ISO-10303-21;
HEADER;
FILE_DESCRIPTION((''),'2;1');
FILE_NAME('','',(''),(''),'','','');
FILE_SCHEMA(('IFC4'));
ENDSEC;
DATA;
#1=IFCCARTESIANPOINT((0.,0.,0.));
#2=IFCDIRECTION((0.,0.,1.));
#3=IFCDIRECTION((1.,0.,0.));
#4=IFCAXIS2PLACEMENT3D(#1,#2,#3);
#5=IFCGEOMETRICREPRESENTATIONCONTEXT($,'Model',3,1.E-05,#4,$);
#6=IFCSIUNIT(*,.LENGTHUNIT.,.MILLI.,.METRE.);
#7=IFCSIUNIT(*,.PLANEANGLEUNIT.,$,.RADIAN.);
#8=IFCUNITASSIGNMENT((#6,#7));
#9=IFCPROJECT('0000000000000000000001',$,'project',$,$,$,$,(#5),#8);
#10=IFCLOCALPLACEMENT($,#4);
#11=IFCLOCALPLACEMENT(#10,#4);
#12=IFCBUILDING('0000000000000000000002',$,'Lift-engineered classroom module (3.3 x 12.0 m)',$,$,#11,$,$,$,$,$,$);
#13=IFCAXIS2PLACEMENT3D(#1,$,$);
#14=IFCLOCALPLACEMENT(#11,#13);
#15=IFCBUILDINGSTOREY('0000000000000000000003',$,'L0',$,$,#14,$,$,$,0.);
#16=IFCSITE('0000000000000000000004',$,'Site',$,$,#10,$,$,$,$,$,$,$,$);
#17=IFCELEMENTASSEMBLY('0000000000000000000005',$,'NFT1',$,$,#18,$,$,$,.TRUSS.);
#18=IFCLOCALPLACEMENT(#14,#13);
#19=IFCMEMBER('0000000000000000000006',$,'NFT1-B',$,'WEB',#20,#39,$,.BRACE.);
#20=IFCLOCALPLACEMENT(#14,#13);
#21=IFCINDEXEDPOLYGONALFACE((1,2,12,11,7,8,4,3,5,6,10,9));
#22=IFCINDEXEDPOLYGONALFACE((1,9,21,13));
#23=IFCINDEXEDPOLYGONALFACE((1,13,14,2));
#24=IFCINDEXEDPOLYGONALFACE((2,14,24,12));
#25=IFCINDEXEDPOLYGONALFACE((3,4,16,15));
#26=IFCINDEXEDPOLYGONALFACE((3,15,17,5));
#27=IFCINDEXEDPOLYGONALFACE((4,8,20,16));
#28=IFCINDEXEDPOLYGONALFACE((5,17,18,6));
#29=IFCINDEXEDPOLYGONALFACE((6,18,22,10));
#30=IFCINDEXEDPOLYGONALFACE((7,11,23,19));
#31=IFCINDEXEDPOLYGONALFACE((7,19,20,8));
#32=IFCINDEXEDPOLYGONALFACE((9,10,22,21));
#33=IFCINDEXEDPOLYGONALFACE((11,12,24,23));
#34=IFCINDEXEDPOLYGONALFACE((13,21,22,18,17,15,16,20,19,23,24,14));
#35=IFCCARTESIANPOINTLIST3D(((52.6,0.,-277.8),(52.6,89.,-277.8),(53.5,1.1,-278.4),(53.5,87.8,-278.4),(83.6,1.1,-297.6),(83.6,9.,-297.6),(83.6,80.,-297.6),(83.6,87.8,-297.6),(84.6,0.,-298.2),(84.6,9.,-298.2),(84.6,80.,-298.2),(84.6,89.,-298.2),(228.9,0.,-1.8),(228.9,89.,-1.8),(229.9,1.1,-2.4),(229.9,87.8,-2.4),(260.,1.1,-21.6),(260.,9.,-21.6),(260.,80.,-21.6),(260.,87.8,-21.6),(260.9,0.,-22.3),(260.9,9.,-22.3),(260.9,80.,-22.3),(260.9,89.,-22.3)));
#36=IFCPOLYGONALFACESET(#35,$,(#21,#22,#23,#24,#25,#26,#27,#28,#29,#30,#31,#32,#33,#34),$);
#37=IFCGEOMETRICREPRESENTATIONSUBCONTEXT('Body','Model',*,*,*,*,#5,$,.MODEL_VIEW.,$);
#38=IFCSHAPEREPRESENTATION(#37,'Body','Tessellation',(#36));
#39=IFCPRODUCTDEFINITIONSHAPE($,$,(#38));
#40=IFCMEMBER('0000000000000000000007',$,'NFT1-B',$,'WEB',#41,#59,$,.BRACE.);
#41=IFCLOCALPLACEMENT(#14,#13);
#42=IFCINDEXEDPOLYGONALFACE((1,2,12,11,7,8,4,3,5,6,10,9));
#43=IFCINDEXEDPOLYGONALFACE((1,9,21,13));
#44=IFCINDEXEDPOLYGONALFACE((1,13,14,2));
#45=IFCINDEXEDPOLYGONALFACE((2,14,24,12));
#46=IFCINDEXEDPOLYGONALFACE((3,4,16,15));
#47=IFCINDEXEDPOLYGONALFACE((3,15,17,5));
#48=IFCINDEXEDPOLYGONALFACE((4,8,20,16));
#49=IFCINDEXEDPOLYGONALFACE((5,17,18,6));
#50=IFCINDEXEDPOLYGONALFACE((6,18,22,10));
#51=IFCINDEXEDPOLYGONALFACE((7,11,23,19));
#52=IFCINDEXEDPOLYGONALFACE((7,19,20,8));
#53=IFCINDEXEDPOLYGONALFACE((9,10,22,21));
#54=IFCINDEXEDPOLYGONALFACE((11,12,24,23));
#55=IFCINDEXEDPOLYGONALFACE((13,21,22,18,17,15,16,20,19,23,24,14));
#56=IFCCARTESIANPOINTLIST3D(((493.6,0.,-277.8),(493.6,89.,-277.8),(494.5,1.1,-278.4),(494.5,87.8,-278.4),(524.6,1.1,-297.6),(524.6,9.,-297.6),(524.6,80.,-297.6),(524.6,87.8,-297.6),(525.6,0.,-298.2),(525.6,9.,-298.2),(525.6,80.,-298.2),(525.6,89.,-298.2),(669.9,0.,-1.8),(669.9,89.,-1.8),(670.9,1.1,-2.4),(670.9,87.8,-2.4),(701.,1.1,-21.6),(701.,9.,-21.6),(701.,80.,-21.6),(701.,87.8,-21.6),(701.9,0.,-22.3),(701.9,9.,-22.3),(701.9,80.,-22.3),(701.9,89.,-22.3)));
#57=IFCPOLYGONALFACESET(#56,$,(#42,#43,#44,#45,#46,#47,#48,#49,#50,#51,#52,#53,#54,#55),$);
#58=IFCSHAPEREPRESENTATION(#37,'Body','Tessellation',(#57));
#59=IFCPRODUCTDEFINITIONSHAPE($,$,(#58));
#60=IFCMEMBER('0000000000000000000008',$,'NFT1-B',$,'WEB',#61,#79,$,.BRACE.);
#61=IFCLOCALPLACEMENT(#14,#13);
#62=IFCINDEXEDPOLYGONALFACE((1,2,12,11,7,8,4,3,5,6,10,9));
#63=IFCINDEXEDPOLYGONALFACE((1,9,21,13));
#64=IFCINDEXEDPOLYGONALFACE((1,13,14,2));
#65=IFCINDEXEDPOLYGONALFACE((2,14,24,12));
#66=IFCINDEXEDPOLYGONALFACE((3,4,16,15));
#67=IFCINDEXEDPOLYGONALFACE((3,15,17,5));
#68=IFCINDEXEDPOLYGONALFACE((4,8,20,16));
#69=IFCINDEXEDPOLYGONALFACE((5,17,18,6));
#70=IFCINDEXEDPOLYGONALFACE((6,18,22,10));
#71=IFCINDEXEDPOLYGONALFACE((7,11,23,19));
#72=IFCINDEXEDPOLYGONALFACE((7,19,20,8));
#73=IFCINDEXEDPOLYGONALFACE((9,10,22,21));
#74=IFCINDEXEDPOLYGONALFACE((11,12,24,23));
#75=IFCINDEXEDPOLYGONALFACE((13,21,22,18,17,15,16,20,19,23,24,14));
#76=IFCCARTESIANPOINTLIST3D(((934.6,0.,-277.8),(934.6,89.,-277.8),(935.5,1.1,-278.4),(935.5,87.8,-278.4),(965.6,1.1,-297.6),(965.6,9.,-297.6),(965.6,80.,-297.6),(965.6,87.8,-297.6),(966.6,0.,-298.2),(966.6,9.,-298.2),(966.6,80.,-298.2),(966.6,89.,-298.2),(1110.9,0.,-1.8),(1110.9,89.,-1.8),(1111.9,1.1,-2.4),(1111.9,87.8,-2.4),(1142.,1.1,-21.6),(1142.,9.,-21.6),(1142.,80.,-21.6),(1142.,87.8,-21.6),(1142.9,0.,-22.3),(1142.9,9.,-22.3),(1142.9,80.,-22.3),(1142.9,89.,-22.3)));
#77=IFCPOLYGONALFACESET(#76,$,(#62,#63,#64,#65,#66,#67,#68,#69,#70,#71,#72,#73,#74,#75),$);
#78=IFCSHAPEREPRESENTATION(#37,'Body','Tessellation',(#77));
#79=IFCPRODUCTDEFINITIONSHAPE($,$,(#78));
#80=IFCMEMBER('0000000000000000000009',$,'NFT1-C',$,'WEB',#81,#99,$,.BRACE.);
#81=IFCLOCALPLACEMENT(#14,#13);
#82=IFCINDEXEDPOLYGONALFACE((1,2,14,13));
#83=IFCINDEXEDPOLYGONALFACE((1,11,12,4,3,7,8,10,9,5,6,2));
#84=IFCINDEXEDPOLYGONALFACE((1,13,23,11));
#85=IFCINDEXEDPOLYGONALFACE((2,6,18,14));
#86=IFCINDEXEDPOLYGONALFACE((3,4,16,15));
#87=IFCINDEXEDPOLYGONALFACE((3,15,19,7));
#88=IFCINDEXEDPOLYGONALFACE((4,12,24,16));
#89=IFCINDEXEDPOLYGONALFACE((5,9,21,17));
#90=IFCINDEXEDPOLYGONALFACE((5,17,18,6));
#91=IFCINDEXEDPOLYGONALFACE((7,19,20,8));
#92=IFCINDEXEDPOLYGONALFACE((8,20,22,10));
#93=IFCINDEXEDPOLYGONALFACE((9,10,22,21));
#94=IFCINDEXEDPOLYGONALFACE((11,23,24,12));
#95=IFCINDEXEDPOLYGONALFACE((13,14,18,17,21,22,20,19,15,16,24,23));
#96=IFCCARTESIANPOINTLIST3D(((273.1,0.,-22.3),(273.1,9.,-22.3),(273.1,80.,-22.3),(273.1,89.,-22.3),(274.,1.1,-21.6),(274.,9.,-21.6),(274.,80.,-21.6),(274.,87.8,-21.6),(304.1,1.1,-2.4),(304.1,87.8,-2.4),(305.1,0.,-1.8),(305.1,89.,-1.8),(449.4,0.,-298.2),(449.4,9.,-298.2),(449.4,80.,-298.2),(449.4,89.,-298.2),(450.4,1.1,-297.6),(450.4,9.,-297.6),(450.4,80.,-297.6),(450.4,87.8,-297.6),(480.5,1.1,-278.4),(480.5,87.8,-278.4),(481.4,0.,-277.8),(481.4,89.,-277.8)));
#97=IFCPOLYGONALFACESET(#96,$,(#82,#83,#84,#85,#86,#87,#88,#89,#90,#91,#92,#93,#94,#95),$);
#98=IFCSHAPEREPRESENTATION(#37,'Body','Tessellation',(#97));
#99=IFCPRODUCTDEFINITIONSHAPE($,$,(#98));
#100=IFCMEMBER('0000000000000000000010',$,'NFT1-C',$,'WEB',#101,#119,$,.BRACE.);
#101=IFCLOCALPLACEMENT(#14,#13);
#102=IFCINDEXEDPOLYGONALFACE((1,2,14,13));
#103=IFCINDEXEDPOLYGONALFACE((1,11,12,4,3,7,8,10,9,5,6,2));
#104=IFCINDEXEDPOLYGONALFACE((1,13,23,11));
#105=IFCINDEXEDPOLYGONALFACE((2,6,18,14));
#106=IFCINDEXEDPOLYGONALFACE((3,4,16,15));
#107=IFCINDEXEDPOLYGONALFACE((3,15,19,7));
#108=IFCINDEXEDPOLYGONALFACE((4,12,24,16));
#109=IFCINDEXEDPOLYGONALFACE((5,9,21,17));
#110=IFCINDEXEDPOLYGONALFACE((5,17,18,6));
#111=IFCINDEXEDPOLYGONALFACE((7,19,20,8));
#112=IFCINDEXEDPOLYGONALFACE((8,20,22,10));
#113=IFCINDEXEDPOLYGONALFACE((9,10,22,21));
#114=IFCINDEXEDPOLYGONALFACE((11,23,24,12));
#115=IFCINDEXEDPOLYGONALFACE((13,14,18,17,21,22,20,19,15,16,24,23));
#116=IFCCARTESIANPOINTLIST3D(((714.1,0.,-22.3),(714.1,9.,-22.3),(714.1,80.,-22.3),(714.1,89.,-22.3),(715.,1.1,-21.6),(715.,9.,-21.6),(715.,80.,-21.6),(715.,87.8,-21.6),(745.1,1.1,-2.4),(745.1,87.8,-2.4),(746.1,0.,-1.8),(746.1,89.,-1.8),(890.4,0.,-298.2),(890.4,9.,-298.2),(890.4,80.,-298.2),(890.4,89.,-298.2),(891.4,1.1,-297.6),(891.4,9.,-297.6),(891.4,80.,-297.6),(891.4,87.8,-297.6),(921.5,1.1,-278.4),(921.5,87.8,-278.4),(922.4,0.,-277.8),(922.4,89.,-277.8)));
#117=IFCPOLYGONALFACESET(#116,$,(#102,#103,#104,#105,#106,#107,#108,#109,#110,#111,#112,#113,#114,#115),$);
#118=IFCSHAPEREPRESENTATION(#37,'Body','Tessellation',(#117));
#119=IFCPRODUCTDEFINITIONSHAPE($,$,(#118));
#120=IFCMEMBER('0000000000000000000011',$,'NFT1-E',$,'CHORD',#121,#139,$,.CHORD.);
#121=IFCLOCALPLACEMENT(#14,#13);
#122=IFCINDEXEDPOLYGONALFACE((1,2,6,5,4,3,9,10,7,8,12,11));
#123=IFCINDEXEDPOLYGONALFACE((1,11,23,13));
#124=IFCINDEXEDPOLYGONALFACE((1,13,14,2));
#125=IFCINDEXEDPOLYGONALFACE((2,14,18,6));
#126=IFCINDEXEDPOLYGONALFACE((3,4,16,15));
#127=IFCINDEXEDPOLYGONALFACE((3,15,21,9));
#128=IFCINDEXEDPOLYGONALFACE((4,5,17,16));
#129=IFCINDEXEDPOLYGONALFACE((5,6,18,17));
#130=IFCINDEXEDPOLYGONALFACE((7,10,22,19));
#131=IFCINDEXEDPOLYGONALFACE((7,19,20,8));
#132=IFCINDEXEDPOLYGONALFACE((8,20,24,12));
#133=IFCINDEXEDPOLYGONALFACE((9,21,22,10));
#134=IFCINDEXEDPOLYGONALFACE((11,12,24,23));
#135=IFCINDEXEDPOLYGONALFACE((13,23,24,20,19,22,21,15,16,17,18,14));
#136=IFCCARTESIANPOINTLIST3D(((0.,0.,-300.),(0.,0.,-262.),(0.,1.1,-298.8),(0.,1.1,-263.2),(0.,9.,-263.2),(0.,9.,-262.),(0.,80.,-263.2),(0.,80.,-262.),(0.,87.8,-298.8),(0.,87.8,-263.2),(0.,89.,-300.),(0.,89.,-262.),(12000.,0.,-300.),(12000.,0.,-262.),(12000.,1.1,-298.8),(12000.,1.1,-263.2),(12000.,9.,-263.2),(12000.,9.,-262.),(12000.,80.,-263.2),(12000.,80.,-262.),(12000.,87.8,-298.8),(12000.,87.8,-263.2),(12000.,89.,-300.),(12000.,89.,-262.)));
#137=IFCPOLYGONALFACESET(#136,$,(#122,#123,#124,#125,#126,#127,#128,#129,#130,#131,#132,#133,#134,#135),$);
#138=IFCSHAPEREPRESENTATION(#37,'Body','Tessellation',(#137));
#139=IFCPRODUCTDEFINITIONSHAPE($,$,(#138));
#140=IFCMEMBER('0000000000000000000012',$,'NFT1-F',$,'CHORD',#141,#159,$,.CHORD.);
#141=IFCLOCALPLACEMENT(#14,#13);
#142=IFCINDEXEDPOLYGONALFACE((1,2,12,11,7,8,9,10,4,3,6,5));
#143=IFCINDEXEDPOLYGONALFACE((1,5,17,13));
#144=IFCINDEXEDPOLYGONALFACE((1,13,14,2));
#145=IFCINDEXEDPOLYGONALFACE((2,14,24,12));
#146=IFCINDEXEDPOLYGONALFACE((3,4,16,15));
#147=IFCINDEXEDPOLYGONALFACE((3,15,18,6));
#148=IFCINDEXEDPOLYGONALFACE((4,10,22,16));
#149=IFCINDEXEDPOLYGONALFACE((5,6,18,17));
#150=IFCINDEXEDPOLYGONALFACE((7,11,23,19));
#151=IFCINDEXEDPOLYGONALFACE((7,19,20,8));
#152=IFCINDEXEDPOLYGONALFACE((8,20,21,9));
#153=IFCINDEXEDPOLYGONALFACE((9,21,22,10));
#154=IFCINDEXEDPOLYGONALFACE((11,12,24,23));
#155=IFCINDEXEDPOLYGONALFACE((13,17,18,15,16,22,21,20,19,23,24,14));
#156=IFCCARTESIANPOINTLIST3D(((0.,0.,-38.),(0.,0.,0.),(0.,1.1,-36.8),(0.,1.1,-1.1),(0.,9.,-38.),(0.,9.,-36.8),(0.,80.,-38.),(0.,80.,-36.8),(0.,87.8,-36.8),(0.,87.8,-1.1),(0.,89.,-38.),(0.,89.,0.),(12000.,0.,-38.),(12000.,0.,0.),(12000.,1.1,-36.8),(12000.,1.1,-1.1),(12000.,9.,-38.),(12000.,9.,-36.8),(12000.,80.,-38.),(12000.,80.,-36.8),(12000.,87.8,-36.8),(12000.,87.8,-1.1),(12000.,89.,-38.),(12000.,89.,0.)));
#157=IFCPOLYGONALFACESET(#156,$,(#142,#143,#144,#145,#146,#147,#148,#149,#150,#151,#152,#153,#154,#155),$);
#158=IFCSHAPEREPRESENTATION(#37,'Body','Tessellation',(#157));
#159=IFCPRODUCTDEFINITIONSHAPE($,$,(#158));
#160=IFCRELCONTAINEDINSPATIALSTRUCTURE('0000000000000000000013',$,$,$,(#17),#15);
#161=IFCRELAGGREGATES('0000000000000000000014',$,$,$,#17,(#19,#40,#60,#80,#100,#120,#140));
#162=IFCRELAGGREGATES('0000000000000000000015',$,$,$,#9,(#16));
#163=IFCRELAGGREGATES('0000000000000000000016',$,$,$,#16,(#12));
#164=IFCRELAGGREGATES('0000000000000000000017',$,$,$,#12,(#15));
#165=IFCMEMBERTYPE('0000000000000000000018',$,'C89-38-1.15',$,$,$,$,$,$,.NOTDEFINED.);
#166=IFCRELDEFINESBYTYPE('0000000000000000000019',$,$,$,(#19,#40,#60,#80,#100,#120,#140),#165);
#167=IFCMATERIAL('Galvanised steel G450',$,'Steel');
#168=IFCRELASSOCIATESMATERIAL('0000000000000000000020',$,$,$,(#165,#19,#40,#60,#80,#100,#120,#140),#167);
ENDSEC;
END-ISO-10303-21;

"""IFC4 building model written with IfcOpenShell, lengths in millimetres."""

from ifc_helpers import new_model, si_unit, frame, origin, origin_with_axes, origin_2d, place, context, subcontext, project, spatial, c_section, extrude, material, material_profile, profile_set, profile_usage, type_object, element, aggregate, save


model = new_model("IFC4")

# Units and contexts
model_context = context("Model", 3, precision=1e-05, world=origin_with_axes())
body_context = subcontext(model_context, "Body", "Model", "MODEL_VIEW")
ifc_project = project(units=[si_unit("LENGTHUNIT", "METRE", prefix="MILLI"), si_unit("PLANEANGLEUNIT", "RADIAN")], contexts=[model_context])

# Site, building, storey
site_placement = place(None, origin_with_axes())
site = spatial("IfcSite", under=ifc_project, at=site_placement, Name="Site")
building_placement = place(site_placement, origin_with_axes())
building = spatial("IfcBuilding", under=site, at=building_placement, Name="Lift-engineered classroom module (3.3 x 12.0 m)")
storey_placement = place(building_placement, origin())
storey = spatial("IfcBuildingStorey", under=building, at=storey_placement, Name="L0", Elevation=0.0)

# Shared definitions
ifc_material = material(Name="Galvanised steel G450", Category="Steel")

# Element assembly, members
assembly_1_placement = place(storey_placement, frame((0.0, 44.5, -300.0)))
assembly_1 = element("IfcElementAssembly", 1, at=assembly_1_placement, inside=storey, Name="NFT1", PredefinedType="TRUSS")
ifc_material_profile_1 = material_profile(ifc_material, c_section(Depth=89.0, Width=38.0, WallThickness=1.1, Girth=9.0, at=origin_2d()), Name="C89-38-1.15")
ifc_profile_set_1 = profile_set([ifc_material_profile_1], Name="C89-38-1.15")
ifc_profile_usage_1 = profile_usage(ifc_profile_set_1)
member_type_1 = type_object("IfcMemberType", Name="C89-38-1.15", PredefinedType="NOTDEFINED", material=ifc_profile_set_1)
member_1_placement = place(assembly_1_placement, frame((68.6, 0.0, 12.0), z_axis=(0.538459, 0.0, 0.842652), x_axis=(0.842652, 0.0, -0.538459)))
member_1 = element("IfcMember", 2, at=member_1_placement, type_object=member_type_1, material=ifc_profile_usage_1, Name="NFT1-B", ObjectType="WEB", PredefinedType="BRACE", context=body_context, shape_type="SweptSolid", body=[
    extrude(c_section(Depth=89.0, Width=38.0, WallThickness=1.1, Girth=9.0, at=origin_2d()), origin(), (0.0, 0.0, 1.0), 327.5),
])
member_2_placement = place(assembly_1_placement, frame((509.6, 0.0, 12.0), z_axis=(0.538459, 0.0, 0.842652), x_axis=(0.842652, 0.0, -0.538459)))
member_2 = element("IfcMember", 3, at=member_2_placement, type_object=member_type_1, material=ifc_profile_usage_1, Name="NFT1-B", ObjectType="WEB", PredefinedType="BRACE", context=body_context, shape_type="SweptSolid", body=[
    extrude(c_section(Depth=89.0, Width=38.0, WallThickness=1.1, Girth=9.0, at=origin_2d()), origin(), (0.0, 0.0, 1.0), 327.5),
])
member_3_placement = place(assembly_1_placement, frame((950.6, 0.0, 12.0), z_axis=(0.538459, 0.0, 0.842652), x_axis=(0.842652, 0.0, -0.538459)))
member_3 = element("IfcMember", 4, at=member_3_placement, type_object=member_type_1, material=ifc_profile_usage_1, Name="NFT1-B", ObjectType="WEB", PredefinedType="BRACE", context=body_context, shape_type="SweptSolid", body=[
    extrude(c_section(Depth=89.0, Width=38.0, WallThickness=1.1, Girth=9.0, at=origin_2d()), origin(), (0.0, 0.0, 1.0), 327.5),
])
member_4_placement = place(assembly_1_placement, frame((465.4, 0.0, 12.0), z_axis=(-0.538459, 0.0, 0.842652), x_axis=(-0.842652, 0.0, -0.538459)))
member_4 = element("IfcMember", 5, at=member_4_placement, type_object=member_type_1, material=ifc_profile_usage_1, Name="NFT1-C", ObjectType="WEB", PredefinedType="BRACE", context=body_context, shape_type="SweptSolid", body=[
    extrude(c_section(Depth=89.0, Width=38.0, WallThickness=1.1, Girth=9.0, at=origin_2d()), origin(), (0.0, 0.0, 1.0), 327.5),
])
member_5_placement = place(assembly_1_placement, frame((906.4, 0.0, 12.0), z_axis=(-0.538459, 0.0, 0.842652), x_axis=(-0.842652, 0.0, -0.538459)))
member_5 = element("IfcMember", 6, at=member_5_placement, type_object=member_type_1, material=ifc_profile_usage_1, Name="NFT1-C", ObjectType="WEB", PredefinedType="BRACE", context=body_context, shape_type="SweptSolid", body=[
    extrude(c_section(Depth=89.0, Width=38.0, WallThickness=1.1, Girth=9.0, at=origin_2d()), origin(), (0.0, 0.0, 1.0), 327.5),
])
member_6_placement = place(assembly_1_placement, frame((0.0, 0.0, 19.0), z_axis=(1.0, 0.0, 0.0), x_axis=(0.0, 0.0, 1.0)))
member_6 = element("IfcMember", 7, at=member_6_placement, type_object=member_type_1, material=ifc_profile_usage_1, Name="NFT1-E", ObjectType="CHORD", PredefinedType="CHORD", context=body_context, shape_type="SweptSolid", body=[
    extrude(c_section(Depth=89.0, Width=38.0, WallThickness=1.1, Girth=9.0, at=origin_2d()), origin(), (0.0, 0.0, 1.0), 12000.0),
])
member_7_placement = place(assembly_1_placement, frame((0.0, 0.0, 281.0), z_axis=(1.0, 0.0, 0.0), x_axis=(0.0, 0.0, -1.0)))
member_7 = element("IfcMember", 8, at=member_7_placement, type_object=member_type_1, material=ifc_profile_usage_1, Name="NFT1-F", ObjectType="CHORD", PredefinedType="CHORD", context=body_context, shape_type="SweptSolid", body=[
    extrude(c_section(Depth=89.0, Width=38.0, WallThickness=1.1, Girth=9.0, at=origin_2d()), origin(), (0.0, 0.0, 1.0), 12000.0),
])
aggregate(assembly_1, [member_1, member_2, member_3, member_4, member_5, member_6, member_7])

save(model, "model.ifc")
